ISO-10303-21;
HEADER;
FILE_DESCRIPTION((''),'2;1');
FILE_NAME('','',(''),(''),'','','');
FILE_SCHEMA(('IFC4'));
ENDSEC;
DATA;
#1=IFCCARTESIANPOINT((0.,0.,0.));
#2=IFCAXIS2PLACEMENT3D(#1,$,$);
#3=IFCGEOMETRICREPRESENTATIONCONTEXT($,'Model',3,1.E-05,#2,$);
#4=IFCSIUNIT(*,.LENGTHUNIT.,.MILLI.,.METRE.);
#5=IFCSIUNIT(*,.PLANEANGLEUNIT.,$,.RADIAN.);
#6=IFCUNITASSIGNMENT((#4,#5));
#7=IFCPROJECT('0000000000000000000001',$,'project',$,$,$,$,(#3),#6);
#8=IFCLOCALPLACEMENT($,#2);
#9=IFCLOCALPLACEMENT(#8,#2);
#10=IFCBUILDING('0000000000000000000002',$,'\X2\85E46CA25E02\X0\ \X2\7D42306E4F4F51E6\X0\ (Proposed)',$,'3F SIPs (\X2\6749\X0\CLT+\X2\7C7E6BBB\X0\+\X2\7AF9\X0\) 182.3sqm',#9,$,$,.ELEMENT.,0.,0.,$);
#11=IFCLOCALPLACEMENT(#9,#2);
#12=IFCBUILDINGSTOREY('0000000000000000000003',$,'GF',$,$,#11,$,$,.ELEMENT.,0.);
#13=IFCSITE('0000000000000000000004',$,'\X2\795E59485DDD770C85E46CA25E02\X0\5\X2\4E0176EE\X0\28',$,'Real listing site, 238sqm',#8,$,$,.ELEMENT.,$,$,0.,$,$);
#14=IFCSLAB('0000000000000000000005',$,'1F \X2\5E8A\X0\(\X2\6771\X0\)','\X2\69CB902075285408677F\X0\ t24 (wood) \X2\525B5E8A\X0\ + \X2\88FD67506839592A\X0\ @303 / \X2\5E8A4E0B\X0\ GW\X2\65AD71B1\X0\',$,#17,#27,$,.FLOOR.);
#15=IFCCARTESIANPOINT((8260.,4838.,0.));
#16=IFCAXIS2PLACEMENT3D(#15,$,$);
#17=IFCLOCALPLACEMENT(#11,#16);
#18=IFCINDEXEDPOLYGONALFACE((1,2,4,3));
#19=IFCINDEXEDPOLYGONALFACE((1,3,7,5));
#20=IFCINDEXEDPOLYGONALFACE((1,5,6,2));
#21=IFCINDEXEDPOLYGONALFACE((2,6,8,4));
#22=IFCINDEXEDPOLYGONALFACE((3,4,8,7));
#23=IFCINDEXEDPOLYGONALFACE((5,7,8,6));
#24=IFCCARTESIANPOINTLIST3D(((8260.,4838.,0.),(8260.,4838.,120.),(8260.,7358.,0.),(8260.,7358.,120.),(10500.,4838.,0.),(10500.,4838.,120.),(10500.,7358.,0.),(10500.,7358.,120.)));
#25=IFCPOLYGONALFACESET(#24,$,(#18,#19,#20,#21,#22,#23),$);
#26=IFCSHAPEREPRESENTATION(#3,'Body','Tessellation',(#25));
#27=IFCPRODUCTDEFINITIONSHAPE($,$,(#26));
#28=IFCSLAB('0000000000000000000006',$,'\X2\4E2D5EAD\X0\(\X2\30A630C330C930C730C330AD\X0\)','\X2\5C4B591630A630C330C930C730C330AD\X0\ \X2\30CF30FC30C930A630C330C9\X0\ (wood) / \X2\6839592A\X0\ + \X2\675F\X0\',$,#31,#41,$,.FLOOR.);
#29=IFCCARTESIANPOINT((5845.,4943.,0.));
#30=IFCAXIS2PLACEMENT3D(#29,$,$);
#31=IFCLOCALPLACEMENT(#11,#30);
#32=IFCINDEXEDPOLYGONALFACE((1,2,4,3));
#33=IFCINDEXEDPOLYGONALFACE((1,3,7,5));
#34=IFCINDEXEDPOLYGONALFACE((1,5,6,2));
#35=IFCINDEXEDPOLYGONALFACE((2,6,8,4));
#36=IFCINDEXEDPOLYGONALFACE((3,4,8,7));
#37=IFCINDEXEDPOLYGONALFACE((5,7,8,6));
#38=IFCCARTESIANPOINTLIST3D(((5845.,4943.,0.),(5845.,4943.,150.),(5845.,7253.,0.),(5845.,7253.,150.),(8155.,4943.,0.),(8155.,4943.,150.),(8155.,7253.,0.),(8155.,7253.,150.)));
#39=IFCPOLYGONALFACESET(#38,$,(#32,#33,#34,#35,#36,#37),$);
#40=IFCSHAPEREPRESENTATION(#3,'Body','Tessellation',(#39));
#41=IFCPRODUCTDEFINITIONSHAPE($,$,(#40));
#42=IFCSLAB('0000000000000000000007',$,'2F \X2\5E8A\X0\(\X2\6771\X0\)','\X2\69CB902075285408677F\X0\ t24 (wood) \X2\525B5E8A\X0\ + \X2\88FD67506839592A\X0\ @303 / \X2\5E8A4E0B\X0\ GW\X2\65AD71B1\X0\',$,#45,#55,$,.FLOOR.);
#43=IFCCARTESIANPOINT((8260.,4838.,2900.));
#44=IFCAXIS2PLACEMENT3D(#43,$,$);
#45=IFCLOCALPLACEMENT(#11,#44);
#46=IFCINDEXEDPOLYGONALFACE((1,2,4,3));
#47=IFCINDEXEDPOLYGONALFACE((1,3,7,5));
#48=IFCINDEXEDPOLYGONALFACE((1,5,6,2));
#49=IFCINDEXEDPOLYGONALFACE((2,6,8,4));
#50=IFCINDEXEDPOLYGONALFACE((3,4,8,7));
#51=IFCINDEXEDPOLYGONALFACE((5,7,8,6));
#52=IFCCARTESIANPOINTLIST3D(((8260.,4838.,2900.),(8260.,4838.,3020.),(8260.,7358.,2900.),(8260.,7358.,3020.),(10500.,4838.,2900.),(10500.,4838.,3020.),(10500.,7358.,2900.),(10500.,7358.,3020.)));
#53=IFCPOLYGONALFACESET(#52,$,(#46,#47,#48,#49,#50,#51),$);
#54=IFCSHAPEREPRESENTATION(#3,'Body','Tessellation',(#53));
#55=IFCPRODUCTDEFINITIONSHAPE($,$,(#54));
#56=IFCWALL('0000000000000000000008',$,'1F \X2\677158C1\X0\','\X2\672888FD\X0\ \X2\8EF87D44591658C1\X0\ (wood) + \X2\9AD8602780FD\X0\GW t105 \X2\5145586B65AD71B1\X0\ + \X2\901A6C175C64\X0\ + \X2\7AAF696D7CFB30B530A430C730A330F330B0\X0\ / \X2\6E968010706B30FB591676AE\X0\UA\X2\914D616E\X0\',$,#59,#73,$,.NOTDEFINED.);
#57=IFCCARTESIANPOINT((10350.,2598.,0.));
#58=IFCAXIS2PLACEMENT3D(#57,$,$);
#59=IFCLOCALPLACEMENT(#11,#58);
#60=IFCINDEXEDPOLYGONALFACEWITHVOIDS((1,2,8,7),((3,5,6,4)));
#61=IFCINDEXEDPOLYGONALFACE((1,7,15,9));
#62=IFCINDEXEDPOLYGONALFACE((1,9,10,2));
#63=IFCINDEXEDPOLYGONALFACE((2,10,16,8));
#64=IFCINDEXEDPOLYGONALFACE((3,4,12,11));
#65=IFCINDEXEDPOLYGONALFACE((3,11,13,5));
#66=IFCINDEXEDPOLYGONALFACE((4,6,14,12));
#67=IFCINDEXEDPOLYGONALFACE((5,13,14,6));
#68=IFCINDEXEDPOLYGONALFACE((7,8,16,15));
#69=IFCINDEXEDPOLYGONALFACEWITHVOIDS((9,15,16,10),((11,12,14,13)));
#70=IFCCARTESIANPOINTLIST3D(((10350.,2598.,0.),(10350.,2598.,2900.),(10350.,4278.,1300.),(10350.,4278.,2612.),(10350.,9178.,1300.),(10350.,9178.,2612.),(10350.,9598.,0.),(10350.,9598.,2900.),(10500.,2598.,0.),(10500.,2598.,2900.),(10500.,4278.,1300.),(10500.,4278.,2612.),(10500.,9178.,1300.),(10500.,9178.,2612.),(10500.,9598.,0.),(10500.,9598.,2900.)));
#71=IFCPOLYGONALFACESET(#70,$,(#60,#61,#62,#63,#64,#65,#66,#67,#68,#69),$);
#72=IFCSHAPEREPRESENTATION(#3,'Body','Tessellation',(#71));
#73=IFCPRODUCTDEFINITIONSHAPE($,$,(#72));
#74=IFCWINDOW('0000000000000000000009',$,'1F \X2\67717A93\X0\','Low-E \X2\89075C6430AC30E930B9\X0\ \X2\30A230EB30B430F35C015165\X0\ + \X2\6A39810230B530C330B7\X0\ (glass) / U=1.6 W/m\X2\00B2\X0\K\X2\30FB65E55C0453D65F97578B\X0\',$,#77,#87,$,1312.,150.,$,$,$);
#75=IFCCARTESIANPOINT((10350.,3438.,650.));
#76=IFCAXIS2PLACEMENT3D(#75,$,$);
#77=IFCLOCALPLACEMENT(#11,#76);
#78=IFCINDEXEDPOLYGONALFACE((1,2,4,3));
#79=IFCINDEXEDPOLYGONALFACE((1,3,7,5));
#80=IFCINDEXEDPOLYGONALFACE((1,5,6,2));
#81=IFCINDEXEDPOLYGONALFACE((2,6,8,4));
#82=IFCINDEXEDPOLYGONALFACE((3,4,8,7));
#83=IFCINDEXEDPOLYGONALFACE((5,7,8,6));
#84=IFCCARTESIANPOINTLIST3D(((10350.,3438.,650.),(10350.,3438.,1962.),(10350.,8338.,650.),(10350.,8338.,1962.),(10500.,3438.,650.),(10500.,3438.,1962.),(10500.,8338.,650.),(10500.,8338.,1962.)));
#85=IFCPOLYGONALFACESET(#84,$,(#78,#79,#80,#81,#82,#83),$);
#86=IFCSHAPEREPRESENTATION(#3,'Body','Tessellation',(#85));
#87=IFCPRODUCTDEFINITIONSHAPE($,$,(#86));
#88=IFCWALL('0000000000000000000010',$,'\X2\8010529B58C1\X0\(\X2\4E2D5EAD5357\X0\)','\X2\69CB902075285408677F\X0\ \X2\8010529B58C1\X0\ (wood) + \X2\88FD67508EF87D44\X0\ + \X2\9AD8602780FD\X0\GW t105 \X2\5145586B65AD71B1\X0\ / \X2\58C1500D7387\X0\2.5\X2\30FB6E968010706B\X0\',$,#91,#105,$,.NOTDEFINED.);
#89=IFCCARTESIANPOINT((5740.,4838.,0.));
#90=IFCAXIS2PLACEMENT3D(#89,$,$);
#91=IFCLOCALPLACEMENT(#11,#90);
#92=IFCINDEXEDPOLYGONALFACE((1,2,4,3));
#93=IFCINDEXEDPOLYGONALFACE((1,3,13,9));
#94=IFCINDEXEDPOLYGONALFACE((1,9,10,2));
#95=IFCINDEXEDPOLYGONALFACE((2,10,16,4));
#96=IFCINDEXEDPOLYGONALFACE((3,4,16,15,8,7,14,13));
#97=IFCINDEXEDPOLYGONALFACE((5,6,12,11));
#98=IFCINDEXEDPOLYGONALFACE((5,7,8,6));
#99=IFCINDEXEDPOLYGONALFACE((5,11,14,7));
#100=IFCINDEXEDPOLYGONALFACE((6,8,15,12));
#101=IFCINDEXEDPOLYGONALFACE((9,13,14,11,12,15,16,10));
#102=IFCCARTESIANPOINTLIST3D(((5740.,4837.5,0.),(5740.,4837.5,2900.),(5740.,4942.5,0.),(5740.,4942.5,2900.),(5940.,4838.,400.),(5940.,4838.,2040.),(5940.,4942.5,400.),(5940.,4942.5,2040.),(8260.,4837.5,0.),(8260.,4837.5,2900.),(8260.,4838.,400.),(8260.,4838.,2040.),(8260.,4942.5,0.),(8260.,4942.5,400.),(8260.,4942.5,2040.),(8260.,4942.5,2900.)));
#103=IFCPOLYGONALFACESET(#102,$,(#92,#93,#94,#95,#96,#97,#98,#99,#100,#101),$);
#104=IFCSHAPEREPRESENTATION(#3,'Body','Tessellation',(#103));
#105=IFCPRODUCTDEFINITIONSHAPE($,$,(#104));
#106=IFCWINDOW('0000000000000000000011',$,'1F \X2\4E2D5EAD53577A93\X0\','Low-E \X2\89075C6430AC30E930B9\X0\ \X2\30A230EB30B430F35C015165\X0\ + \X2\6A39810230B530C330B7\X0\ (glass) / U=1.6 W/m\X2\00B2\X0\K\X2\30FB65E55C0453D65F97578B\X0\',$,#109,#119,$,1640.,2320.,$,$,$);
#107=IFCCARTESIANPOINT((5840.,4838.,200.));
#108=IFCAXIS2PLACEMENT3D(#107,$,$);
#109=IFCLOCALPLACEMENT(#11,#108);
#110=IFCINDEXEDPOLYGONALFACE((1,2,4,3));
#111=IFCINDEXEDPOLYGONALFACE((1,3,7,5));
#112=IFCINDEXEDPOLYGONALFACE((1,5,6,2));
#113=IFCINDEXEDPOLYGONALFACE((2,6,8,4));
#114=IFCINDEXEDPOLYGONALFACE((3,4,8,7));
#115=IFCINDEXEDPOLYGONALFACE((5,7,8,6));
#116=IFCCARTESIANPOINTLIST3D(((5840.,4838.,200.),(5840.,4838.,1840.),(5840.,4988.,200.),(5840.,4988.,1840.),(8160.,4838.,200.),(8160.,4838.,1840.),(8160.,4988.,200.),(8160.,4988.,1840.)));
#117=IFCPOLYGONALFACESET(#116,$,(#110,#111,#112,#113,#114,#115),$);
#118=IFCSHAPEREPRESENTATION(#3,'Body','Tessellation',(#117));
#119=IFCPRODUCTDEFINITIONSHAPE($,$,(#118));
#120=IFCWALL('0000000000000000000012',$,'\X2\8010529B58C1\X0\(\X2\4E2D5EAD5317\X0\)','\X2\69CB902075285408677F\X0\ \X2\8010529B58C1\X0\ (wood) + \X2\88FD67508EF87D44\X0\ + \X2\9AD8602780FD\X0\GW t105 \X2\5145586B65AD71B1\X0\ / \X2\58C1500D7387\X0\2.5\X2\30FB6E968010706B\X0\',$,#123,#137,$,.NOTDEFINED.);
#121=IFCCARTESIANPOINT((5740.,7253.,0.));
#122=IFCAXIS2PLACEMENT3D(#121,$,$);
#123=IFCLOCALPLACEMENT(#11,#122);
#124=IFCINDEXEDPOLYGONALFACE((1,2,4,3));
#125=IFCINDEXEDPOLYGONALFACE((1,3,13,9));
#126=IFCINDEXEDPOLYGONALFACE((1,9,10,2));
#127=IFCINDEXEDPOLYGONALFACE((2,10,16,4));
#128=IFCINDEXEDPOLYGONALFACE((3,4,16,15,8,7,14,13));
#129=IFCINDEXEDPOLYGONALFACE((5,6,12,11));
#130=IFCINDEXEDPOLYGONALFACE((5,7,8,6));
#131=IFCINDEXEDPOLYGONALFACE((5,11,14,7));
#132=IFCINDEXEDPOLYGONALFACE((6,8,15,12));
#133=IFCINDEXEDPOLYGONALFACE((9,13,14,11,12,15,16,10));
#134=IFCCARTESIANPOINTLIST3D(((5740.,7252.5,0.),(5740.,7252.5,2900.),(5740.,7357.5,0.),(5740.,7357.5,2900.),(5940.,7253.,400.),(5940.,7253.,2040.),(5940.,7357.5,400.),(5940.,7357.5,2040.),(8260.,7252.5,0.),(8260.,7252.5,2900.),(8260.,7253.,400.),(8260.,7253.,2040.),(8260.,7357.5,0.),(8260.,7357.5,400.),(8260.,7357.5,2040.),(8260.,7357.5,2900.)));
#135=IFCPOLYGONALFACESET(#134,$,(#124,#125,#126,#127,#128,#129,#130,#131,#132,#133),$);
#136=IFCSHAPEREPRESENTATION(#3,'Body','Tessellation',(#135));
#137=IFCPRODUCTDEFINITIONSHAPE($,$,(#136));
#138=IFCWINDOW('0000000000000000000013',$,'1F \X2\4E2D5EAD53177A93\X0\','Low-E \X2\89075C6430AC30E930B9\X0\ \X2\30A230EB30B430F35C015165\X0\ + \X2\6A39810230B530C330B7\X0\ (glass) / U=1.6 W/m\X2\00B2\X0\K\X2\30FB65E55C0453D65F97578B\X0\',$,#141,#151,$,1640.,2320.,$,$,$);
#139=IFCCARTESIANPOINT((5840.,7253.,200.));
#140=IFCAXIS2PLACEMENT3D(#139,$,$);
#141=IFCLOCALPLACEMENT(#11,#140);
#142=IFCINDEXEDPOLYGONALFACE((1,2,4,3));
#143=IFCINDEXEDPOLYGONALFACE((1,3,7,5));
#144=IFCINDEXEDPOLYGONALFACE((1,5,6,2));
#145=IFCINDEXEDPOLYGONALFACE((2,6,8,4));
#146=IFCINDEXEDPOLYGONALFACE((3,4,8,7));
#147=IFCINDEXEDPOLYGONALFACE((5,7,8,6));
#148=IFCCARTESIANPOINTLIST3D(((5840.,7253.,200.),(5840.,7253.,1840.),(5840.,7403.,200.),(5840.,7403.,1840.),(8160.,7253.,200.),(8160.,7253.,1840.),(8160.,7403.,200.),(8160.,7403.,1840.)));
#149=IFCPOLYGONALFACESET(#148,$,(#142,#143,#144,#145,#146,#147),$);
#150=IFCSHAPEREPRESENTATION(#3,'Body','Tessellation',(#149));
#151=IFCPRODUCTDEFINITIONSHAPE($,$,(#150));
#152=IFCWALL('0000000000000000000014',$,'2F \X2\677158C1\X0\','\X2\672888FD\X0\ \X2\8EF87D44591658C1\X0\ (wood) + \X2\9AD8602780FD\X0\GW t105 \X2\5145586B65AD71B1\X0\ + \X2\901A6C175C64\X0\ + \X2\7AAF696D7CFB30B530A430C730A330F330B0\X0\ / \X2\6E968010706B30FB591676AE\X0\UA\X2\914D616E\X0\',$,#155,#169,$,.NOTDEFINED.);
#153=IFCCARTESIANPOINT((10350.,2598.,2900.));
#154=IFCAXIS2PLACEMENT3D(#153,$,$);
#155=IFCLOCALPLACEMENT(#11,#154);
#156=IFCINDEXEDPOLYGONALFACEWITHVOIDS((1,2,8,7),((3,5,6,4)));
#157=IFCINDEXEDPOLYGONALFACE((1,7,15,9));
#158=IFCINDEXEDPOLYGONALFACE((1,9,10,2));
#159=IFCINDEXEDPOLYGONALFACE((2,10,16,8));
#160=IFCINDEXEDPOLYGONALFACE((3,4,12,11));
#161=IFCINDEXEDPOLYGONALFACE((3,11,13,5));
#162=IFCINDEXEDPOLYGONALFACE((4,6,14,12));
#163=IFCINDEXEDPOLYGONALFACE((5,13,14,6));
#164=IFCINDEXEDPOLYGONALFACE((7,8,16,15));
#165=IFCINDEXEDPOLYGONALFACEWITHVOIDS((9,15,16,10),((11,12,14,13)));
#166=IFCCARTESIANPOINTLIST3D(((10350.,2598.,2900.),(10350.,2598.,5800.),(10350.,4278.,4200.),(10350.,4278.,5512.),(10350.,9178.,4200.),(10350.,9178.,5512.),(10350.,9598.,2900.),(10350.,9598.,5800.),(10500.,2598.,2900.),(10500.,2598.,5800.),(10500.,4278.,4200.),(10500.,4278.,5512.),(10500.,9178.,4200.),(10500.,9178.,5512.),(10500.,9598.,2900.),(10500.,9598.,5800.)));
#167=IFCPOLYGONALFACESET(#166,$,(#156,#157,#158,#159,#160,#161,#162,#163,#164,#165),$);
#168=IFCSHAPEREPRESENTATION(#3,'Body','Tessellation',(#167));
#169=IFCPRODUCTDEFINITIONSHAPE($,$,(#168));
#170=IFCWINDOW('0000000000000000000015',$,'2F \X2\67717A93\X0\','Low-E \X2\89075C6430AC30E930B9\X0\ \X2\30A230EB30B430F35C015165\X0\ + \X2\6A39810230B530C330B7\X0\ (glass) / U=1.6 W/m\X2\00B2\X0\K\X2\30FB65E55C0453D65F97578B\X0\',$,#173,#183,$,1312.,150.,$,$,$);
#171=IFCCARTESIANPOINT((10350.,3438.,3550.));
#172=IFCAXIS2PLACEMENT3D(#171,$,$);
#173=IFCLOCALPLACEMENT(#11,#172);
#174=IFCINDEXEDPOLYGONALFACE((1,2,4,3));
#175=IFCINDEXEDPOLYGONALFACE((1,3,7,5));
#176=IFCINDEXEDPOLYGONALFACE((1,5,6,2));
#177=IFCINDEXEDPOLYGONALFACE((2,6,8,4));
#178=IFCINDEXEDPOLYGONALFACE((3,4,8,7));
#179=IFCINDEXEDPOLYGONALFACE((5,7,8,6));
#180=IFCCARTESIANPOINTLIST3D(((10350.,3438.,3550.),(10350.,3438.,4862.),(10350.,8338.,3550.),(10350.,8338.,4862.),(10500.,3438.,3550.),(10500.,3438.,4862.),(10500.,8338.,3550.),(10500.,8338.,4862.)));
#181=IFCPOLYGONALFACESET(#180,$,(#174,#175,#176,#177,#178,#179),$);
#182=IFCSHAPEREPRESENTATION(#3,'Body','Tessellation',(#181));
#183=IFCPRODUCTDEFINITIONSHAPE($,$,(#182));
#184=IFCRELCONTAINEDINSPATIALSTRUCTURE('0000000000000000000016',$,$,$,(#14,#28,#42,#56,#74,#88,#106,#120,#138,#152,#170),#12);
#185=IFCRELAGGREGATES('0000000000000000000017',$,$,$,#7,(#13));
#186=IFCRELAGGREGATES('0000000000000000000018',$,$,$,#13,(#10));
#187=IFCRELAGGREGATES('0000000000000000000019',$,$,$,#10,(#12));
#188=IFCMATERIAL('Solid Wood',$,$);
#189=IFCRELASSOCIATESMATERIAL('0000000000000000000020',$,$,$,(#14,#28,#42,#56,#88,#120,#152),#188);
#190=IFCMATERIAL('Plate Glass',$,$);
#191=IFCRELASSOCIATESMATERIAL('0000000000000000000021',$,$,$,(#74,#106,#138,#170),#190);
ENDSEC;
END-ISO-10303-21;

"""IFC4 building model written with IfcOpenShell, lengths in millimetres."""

from ifc_helpers import new_model, si_unit, frame, frame_2d, origin, place, context, project, spatial, rectangle, extrude, material, element, fill, save


model = new_model("IFC4")

# Units and contexts
model_context = context("Model", 3, precision=1e-05, world=origin())
ifc_project = project(units=[si_unit("LENGTHUNIT", "METRE", prefix="MILLI"), si_unit("PLANEANGLEUNIT", "RADIAN")], contexts=[model_context])

# Site, building, storey
site_placement = place(None, origin())
site = spatial("IfcSite", under=ifc_project, at=site_placement, Name="神奈川県藤沢市5丁目28", ObjectType="Real listing site, 238sqm", CompositionType="ELEMENT", RefElevation=0.0)
building_placement = place(site_placement, origin())
building = spatial("IfcBuilding", under=site, at=building_placement, Name="藤沢市 終の住処 (Proposed)", ObjectType="3F SIPs (杉CLT+籾殻+竹) 182.3sqm", CompositionType="ELEMENT", ElevationOfRefHeight=0.0, ElevationOfTerrain=0.0)
storey_placement = place(building_placement, origin())
storey = spatial("IfcBuildingStorey", under=building, at=storey_placement, Name="GF", CompositionType="ELEMENT", Elevation=0.0)

# Slabs
ifc_material_1 = material(Name="Solid Wood")
slab_1_placement = place(storey_placement, frame((8260.0, 4838.0, 0.0)))
element("IfcSlab", 1, at=slab_1_placement, inside=storey, material=ifc_material_1, Name="1F 床(東)", Description="構造用合板 t24 (wood) 剛床 + 製材根太 @303 / 床下 GW断熱", PredefinedType="FLOOR", context=model_context, shape_type="SweptSolid", body=[
    extrude(rectangle(XDim=2240.0, YDim=2520.0, at=frame_2d((1120.0, 1260.0))), frame((8260.0, 4838.0, 0.0)), (0.0, 0.0, 1.0), 120.0),
])
slab_2_placement = place(storey_placement, frame((5845.0, 4943.0, 0.0)))
element("IfcSlab", 2, at=slab_2_placement, inside=storey, material=ifc_material_1, Name="中庭(ウッドデッキ)", Description="屋外ウッドデッキ ハードウッド (wood) / 根太 + 束", PredefinedType="FLOOR", context=model_context, shape_type="SweptSolid", body=[
    extrude(rectangle(XDim=2310.0, YDim=2310.0, at=frame_2d((1155.0, 1155.0))), frame((5845.0, 4943.0, 0.0)), (0.0, 0.0, 1.0), 150.0),
])
slab_3_placement = place(storey_placement, frame((8260.0, 4838.0, 2900.0)))
element("IfcSlab", 3, at=slab_3_placement, inside=storey, material=ifc_material_1, Name="2F 床(東)", Description="構造用合板 t24 (wood) 剛床 + 製材根太 @303 / 床下 GW断熱", PredefinedType="FLOOR", context=model_context, shape_type="SweptSolid", body=[
    extrude(rectangle(XDim=2240.0, YDim=2520.0, at=frame_2d((1120.0, 1260.0))), frame((8260.0, 4838.0, 2900.0)), (0.0, 0.0, 1.0), 120.0),
])

# Walls, openings, windows
wall_1_placement = place(storey_placement, frame((10350.0, 2598.0, 0.0)))
wall_1 = element("IfcWall", 4, at=wall_1_placement, inside=storey, material=ifc_material_1, Name="1F 東壁", Description="木製 軸組外壁 (wood) + 高性能GW t105 充填断熱 + 通気層 + 窯業系サイディング / 準耐火・外皮UA配慮", PredefinedType="NOTDEFINED", context=model_context, shape_type="SweptSolid", body=[
    extrude(rectangle(XDim=150.0, YDim=7000.0, at=frame_2d((75.0, 3500.0))), frame((10350.0, 2598.0, 0.0)), (0.0, 0.0, 1.0), 2900.0),
])
opening_1_placement = place(storey_placement, frame((10350.0, 3438.0, 650.0)))
opening_1 = element("IfcOpeningElement", 5, at=opening_1_placement, cuts=wall_1, PredefinedType="NOTDEFINED", context=model_context, shape_type="SweptSolid", body=[
    extrude(rectangle(XDim=150.0, YDim=4900.0, at=frame_2d((75.0, 2450.0))), frame((10350.0, 3438.0, 650.0)), (0.0, 0.0, 1.0), 1312.0),
])
ifc_material_2 = material(Name="Plate Glass")
window_1_placement = place(storey_placement, frame((10350.0, 3438.0, 650.0)))
window_1 = element("IfcWindow", 6, at=window_1_placement, inside=storey, material=ifc_material_2, Name="1F 東窓", Description="Low-E 複層ガラス アルゴン封入 + 樹脂サッシ (glass) / U=1.6 W/m²K・日射取得型", OverallHeight=1312.0, OverallWidth=150.0, context=model_context, shape_type="SweptSolid", body=[
    extrude(rectangle(XDim=150.0, YDim=4900.0, at=frame_2d((75.0, 2450.0))), frame((10350.0, 3438.0, 650.0)), (0.0, 0.0, 1.0), 1312.0),
])
fill(opening_1, window_1)
wall_2_placement = place(storey_placement, frame((5740.0, 4838.0, 0.0)))
wall_2 = element("IfcWall", 7, at=wall_2_placement, inside=storey, material=ifc_material_1, Name="耐力壁(中庭南)", Description="構造用合板 耐力壁 (wood) + 製材軸組 + 高性能GW t105 充填断熱 / 壁倍率2.5・準耐火", PredefinedType="NOTDEFINED", context=model_context, shape_type="SweptSolid", body=[
    extrude(rectangle(XDim=2520.0, YDim=105.0, at=frame_2d((1260.0, 52.0))), frame((5740.0, 4838.0, 0.0)), (0.0, 0.0, 1.0), 2900.0),
])
opening_2_placement = place(storey_placement, frame((5840.0, 4838.0, 200.0)))
opening_2 = element("IfcOpeningElement", 8, at=opening_2_placement, cuts=wall_2, PredefinedType="NOTDEFINED", context=model_context, shape_type="SweptSolid", body=[
    extrude(rectangle(XDim=2320.0, YDim=150.0, at=frame_2d((1160.0, 75.0))), frame((5840.0, 4838.0, 200.0)), (0.0, 0.0, 1.0), 1640.0),
])
window_2_placement = place(storey_placement, frame((5840.0, 4838.0, 200.0)))
window_2 = element("IfcWindow", 9, at=window_2_placement, inside=storey, material=ifc_material_2, Name="1F 中庭南窓", Description="Low-E 複層ガラス アルゴン封入 + 樹脂サッシ (glass) / U=1.6 W/m²K・日射取得型", OverallHeight=1640.0, OverallWidth=2320.0, context=model_context, shape_type="SweptSolid", body=[
    extrude(rectangle(XDim=2320.0, YDim=150.0, at=frame_2d((1160.0, 75.0))), frame((5840.0, 4838.0, 200.0)), (0.0, 0.0, 1.0), 1640.0),
])
fill(opening_2, window_2)
wall_3_placement = place(storey_placement, frame((5740.0, 7253.0, 0.0)))
wall_3 = element("IfcWall", 10, at=wall_3_placement, inside=storey, material=ifc_material_1, Name="耐力壁(中庭北)", Description="構造用合板 耐力壁 (wood) + 製材軸組 + 高性能GW t105 充填断熱 / 壁倍率2.5・準耐火", PredefinedType="NOTDEFINED", context=model_context, shape_type="SweptSolid", body=[
    extrude(rectangle(XDim=2520.0, YDim=105.0, at=frame_2d((1260.0, 52.0))), frame((5740.0, 7253.0, 0.0)), (0.0, 0.0, 1.0), 2900.0),
])
opening_3_placement = place(storey_placement, frame((5840.0, 7253.0, 200.0)))
opening_3 = element("IfcOpeningElement", 11, at=opening_3_placement, cuts=wall_3, PredefinedType="NOTDEFINED", context=model_context, shape_type="SweptSolid", body=[
    extrude(rectangle(XDim=2320.0, YDim=150.0, at=frame_2d((1160.0, 75.0))), frame((5840.0, 7253.0, 200.0)), (0.0, 0.0, 1.0), 1640.0),
])
window_3_placement = place(storey_placement, frame((5840.0, 7253.0, 200.0)))
window_3 = element("IfcWindow", 12, at=window_3_placement, inside=storey, material=ifc_material_2, Name="1F 中庭北窓", Description="Low-E 複層ガラス アルゴン封入 + 樹脂サッシ (glass) / U=1.6 W/m²K・日射取得型", OverallHeight=1640.0, OverallWidth=2320.0, context=model_context, shape_type="SweptSolid", body=[
    extrude(rectangle(XDim=2320.0, YDim=150.0, at=frame_2d((1160.0, 75.0))), frame((5840.0, 7253.0, 200.0)), (0.0, 0.0, 1.0), 1640.0),
])
fill(opening_3, window_3)

# Wall, opening, window
wall_4_placement = place(storey_placement, frame((10350.0, 2598.0, 2900.0)))
wall_4 = element("IfcWall", 13, at=wall_4_placement, inside=storey, material=ifc_material_1, Name="2F 東壁", Description="木製 軸組外壁 (wood) + 高性能GW t105 充填断熱 + 通気層 + 窯業系サイディング / 準耐火・外皮UA配慮", PredefinedType="NOTDEFINED", context=model_context, shape_type="SweptSolid", body=[
    extrude(rectangle(XDim=150.0, YDim=7000.0, at=frame_2d((75.0, 3500.0))), frame((10350.0, 2598.0, 2900.0)), (0.0, 0.0, 1.0), 2900.0),
])
opening_4_placement = place(storey_placement, frame((10350.0, 3438.0, 3550.0)))
opening_4 = element("IfcOpeningElement", 14, at=opening_4_placement, cuts=wall_4, PredefinedType="NOTDEFINED", context=model_context, shape_type="SweptSolid", body=[
    extrude(rectangle(XDim=150.0, YDim=4900.0, at=frame_2d((75.0, 2450.0))), frame((10350.0, 3438.0, 3550.0)), (0.0, 0.0, 1.0), 1312.0),
])
window_4_placement = place(storey_placement, frame((10350.0, 3438.0, 3550.0)))
window_4 = element("IfcWindow", 15, at=window_4_placement, inside=storey, material=ifc_material_2, Name="2F 東窓", Description="Low-E 複層ガラス アルゴン封入 + 樹脂サッシ (glass) / U=1.6 W/m²K・日射取得型", OverallHeight=1312.0, OverallWidth=150.0, context=model_context, shape_type="SweptSolid", body=[
    extrude(rectangle(XDim=150.0, YDim=4900.0, at=frame_2d((75.0, 2450.0))), frame((10350.0, 3438.0, 3550.0)), (0.0, 0.0, 1.0), 1312.0),
])
fill(opening_4, window_4)

save(model, "model.ifc")
